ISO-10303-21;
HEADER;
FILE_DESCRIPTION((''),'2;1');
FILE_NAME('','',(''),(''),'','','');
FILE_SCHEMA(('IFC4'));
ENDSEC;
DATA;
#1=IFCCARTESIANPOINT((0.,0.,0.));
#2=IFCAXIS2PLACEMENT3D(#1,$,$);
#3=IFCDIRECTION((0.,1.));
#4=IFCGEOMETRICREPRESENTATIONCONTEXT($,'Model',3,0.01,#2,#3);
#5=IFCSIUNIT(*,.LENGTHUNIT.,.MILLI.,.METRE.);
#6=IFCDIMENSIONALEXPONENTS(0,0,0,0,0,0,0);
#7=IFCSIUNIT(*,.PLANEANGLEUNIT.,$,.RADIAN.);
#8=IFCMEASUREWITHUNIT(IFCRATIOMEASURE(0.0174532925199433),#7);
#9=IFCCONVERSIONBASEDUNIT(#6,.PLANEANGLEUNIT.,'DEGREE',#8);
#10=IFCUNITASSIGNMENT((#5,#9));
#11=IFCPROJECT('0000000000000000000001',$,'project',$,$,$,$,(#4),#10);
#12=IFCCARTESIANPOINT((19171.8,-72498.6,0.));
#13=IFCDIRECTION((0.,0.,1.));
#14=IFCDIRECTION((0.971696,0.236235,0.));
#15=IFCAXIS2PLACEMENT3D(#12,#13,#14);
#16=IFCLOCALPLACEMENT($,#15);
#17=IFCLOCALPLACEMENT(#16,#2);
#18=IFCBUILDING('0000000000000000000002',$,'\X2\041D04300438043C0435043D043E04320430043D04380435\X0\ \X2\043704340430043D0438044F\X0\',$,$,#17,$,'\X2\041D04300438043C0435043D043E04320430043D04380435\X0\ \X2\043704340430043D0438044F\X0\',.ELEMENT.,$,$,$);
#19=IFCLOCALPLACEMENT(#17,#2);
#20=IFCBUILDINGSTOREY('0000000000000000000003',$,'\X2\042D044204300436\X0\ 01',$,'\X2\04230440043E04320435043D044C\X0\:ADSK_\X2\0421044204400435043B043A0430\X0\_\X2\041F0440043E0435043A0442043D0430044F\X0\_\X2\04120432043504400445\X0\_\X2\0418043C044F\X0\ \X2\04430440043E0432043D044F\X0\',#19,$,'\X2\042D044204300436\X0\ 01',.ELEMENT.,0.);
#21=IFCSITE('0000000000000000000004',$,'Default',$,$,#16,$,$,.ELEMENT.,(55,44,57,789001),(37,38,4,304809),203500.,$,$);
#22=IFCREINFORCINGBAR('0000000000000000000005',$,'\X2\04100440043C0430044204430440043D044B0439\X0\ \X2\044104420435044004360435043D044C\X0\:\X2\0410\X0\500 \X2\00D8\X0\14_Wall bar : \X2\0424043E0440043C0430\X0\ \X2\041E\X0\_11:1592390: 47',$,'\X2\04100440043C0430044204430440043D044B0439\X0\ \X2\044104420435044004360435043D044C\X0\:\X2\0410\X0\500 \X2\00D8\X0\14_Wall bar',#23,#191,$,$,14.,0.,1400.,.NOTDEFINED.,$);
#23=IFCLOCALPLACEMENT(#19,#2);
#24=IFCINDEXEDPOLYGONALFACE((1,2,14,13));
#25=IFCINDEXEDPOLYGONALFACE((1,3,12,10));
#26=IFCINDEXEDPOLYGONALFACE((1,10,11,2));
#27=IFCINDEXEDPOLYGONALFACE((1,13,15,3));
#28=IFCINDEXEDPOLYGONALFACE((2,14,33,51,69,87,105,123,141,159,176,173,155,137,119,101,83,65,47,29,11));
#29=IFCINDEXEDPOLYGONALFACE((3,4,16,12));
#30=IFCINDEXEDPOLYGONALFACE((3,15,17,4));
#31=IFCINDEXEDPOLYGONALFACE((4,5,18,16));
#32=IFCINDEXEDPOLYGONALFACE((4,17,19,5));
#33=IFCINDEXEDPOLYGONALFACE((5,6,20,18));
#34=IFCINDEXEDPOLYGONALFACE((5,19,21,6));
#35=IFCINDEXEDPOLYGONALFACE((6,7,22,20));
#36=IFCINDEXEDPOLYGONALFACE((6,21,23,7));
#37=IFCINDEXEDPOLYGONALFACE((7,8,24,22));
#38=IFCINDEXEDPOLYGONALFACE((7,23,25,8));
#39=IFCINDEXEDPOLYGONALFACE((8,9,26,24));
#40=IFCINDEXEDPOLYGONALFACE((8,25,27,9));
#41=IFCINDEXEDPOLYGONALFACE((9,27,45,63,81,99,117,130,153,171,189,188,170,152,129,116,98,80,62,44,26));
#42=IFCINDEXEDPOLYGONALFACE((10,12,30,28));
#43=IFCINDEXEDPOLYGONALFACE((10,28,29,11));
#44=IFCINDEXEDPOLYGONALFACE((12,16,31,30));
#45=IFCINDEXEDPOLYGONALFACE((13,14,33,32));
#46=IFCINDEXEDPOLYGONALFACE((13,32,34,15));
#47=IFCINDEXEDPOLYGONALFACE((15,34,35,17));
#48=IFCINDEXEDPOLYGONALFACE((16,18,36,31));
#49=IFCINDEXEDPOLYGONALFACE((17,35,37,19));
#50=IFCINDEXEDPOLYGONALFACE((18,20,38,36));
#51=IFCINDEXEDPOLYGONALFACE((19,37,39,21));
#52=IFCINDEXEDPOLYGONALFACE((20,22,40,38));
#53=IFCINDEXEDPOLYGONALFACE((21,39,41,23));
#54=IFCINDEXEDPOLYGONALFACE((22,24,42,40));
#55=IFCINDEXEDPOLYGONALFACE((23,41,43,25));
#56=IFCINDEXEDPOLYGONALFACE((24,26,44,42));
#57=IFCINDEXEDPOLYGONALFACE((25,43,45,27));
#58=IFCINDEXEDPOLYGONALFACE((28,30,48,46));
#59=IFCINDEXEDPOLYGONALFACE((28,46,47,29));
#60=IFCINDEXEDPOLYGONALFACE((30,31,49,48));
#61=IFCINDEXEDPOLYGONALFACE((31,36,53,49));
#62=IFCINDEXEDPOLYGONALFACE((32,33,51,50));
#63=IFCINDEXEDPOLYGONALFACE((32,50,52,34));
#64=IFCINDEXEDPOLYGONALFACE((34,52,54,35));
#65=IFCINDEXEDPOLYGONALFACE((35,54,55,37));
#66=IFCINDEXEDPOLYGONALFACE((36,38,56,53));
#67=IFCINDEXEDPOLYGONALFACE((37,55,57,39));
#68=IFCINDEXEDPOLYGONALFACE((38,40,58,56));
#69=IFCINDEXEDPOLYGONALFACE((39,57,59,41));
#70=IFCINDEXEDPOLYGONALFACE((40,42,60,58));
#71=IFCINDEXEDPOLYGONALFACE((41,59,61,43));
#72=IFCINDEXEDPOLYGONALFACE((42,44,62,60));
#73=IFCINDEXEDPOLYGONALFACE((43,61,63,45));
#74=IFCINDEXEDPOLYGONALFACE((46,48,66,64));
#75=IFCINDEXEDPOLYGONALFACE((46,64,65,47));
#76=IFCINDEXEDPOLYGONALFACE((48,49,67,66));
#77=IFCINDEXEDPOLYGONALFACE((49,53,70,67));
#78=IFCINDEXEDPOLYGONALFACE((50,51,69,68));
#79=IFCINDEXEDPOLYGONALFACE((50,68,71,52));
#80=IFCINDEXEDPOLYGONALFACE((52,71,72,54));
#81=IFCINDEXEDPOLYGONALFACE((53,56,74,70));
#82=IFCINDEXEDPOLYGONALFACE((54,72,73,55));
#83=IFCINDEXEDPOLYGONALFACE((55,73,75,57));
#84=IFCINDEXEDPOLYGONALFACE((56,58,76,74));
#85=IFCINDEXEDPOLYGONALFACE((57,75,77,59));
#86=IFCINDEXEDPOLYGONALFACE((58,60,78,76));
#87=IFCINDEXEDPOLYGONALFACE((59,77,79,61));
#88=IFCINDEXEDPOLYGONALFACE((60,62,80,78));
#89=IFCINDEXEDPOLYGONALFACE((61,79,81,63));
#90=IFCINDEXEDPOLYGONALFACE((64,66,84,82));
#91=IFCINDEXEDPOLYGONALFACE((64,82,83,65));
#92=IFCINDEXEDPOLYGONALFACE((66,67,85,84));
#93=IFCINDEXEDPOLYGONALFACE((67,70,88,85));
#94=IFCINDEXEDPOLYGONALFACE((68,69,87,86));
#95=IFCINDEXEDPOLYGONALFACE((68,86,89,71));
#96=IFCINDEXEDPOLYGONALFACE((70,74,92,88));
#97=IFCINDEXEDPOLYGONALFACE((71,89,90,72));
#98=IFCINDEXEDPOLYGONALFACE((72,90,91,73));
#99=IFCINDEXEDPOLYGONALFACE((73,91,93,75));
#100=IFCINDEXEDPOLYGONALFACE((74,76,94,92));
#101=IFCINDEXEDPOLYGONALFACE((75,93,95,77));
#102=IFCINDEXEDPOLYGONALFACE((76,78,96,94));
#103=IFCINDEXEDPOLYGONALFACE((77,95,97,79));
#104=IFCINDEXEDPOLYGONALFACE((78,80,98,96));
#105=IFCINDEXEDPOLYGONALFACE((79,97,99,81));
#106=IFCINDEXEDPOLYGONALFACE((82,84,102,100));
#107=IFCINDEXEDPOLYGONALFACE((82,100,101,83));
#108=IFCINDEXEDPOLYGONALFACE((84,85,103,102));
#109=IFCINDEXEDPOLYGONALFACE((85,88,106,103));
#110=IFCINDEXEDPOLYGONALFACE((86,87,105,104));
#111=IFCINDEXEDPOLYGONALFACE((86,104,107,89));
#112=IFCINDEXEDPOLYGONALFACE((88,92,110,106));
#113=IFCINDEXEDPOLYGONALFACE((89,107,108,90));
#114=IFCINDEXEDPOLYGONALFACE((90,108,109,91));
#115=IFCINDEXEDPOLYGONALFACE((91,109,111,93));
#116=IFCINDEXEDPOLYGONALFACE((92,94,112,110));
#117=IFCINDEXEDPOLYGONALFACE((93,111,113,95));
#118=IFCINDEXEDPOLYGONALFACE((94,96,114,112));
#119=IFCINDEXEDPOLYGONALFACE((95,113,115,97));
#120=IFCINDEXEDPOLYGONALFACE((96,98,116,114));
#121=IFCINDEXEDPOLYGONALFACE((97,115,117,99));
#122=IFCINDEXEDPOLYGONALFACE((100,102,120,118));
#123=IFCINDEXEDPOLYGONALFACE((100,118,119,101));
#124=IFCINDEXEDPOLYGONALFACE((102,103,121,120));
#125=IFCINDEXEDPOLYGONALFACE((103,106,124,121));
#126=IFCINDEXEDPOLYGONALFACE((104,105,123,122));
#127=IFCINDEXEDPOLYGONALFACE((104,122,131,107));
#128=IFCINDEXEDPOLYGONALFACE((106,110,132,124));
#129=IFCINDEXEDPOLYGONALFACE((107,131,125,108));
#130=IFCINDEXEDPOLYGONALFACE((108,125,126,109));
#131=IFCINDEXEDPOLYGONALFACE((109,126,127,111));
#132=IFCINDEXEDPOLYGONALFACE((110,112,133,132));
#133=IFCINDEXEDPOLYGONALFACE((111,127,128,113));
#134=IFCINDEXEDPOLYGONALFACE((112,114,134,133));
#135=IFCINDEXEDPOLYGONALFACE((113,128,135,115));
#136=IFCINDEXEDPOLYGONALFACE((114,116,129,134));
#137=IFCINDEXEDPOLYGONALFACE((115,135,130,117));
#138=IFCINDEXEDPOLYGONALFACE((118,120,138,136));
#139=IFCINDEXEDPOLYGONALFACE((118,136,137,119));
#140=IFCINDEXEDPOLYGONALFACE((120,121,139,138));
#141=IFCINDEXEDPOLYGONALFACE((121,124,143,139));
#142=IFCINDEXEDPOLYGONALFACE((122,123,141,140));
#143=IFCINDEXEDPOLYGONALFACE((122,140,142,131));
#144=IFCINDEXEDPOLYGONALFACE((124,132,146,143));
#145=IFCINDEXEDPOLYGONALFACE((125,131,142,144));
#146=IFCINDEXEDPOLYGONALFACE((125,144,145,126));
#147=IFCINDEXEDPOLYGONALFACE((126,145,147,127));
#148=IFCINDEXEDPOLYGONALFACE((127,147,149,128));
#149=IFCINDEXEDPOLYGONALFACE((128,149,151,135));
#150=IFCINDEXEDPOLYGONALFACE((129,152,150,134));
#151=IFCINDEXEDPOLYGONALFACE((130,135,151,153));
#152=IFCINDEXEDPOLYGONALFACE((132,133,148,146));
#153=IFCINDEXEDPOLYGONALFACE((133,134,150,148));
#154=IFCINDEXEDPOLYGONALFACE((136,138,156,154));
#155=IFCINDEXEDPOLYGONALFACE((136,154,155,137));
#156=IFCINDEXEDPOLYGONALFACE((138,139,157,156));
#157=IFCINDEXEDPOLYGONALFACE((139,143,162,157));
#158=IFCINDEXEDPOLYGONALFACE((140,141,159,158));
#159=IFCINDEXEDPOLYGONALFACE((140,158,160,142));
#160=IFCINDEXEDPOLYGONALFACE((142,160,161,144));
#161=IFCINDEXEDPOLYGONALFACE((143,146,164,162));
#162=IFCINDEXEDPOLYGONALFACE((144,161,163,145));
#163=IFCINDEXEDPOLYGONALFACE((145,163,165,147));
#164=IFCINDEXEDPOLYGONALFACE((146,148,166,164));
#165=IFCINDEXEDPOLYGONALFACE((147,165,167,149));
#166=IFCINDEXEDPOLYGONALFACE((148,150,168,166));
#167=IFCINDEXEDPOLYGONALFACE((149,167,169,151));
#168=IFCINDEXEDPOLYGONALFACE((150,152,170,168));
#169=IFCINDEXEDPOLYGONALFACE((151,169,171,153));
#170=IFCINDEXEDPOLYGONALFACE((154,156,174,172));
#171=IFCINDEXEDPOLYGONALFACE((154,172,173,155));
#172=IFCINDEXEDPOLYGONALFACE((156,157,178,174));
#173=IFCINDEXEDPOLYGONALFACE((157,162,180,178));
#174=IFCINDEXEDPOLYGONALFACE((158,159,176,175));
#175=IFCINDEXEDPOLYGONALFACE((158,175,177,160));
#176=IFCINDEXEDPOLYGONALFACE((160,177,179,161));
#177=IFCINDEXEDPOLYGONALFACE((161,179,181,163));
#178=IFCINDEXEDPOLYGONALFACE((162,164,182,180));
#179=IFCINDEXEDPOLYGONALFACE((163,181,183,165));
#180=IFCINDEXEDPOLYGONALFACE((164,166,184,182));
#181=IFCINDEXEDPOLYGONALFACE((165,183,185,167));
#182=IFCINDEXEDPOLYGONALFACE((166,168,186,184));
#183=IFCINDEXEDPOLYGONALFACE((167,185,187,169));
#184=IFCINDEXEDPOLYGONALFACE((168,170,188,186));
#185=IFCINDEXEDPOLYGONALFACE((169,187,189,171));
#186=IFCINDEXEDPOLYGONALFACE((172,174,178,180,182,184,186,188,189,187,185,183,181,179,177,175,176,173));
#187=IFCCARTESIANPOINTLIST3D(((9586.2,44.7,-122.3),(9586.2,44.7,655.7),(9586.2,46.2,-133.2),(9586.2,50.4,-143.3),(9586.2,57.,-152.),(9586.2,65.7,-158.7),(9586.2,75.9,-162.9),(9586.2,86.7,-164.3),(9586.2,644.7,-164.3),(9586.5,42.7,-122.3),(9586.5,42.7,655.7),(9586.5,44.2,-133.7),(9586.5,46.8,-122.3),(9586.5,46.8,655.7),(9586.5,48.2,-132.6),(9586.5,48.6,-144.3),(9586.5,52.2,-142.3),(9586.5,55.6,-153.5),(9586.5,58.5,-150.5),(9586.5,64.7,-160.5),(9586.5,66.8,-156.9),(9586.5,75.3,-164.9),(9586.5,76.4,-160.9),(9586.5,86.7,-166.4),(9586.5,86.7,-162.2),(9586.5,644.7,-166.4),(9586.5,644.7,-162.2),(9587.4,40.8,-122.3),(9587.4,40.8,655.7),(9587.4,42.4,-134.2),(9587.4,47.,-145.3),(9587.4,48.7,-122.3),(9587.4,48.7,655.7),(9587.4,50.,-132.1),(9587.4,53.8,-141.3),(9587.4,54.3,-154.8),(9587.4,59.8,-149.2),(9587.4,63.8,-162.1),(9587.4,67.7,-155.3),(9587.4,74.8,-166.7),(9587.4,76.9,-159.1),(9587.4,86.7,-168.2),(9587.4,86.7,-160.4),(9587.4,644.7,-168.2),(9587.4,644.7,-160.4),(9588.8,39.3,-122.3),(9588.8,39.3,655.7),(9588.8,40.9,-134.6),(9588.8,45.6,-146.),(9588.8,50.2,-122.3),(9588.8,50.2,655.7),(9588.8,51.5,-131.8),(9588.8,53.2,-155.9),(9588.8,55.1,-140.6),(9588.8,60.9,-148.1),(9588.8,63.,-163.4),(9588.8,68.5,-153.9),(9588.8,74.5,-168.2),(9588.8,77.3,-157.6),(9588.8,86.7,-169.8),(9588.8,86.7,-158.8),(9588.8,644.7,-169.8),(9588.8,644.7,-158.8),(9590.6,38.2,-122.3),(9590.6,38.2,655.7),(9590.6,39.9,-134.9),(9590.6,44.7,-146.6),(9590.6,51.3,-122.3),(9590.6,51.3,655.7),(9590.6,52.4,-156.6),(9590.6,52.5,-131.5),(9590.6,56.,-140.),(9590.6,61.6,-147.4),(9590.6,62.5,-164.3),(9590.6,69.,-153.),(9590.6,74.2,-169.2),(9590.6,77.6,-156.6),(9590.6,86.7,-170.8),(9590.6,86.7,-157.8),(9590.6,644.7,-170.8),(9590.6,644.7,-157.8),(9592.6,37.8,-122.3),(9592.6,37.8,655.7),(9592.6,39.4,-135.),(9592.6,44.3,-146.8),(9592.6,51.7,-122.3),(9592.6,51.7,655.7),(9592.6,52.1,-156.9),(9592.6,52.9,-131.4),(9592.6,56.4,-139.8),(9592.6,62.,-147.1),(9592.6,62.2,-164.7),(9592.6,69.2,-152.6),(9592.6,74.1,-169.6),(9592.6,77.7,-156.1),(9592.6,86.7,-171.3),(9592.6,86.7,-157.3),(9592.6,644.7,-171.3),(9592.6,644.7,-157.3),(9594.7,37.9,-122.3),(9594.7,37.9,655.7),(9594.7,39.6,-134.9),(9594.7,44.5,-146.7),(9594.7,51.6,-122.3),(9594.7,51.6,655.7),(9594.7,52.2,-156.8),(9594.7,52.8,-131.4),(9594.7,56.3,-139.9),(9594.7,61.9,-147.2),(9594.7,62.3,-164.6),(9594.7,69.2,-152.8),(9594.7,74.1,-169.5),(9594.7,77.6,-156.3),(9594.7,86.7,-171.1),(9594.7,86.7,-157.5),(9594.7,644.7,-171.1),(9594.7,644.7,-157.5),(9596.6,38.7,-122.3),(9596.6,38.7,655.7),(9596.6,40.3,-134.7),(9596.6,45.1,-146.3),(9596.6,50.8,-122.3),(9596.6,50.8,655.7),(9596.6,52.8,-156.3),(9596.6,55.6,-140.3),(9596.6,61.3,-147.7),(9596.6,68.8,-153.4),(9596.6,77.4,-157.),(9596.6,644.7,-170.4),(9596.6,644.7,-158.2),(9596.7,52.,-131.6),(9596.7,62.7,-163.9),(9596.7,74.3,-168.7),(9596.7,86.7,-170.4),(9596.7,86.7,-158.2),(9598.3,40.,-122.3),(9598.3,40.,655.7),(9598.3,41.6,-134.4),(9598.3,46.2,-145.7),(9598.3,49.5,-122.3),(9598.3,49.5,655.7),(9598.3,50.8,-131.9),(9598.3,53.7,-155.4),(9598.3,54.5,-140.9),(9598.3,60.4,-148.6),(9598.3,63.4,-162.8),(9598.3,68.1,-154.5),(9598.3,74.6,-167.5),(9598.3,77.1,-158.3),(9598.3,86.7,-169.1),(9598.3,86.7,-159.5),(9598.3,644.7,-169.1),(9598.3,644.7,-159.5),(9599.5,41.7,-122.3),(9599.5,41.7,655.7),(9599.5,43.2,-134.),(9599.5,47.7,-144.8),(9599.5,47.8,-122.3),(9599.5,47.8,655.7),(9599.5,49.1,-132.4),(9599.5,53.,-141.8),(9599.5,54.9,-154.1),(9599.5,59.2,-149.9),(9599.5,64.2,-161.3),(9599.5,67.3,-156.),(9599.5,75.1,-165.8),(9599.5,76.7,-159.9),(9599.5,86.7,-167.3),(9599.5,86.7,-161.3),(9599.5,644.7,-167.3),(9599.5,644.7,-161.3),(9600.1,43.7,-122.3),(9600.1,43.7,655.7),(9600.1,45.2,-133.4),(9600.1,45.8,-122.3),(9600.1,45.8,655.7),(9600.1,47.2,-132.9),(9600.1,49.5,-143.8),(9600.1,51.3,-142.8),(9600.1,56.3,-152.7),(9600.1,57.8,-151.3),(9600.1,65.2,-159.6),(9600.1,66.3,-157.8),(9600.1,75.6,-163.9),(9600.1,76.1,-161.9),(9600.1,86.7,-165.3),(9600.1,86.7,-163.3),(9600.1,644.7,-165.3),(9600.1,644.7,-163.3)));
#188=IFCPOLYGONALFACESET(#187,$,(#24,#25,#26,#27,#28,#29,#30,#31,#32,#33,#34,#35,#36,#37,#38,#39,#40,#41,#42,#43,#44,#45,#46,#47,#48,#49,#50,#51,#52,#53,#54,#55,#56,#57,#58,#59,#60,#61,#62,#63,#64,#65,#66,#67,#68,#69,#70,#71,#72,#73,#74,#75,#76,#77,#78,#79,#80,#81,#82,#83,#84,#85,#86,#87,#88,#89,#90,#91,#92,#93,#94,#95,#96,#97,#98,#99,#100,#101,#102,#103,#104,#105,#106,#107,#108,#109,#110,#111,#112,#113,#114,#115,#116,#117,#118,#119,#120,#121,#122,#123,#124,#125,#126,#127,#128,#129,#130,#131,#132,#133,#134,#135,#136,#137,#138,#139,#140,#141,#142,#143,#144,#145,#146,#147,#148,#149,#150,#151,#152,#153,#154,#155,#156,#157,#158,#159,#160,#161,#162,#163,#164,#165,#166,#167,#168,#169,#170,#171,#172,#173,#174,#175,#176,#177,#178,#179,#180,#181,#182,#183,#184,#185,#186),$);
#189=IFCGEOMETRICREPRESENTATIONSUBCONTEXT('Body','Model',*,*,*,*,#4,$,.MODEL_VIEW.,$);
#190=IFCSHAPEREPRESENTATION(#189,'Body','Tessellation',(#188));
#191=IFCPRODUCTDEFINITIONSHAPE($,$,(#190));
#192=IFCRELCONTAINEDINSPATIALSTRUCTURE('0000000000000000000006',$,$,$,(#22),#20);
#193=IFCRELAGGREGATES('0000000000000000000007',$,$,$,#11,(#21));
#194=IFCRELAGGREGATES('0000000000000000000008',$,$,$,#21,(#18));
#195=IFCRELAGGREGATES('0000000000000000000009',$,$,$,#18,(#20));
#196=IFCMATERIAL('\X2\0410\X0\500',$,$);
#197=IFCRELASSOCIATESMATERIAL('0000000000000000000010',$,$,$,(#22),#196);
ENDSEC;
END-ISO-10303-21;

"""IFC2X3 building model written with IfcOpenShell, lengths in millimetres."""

from ifc_helpers import new_model, entity, si_unit, converted_unit, direction, frame, origin, place, context, subcontext, project, spatial, material, element, save


model = new_model("IFC2X3")

# Units and contexts
model_context = context("Model", 3, precision=0.01, world=origin(), true_north=direction((0.0, 1.0)))
body_context = subcontext(model_context, "Body", "Model", "MODEL_VIEW")
ifc_project = project(units=[si_unit("LENGTHUNIT", "METRE", prefix="MILLI"), converted_unit("PLANEANGLEUNIT", "DEGREE", entity("IfcRatioMeasure", 0.0174532925199433), si_unit("PLANEANGLEUNIT", "RADIAN"), dimensions=[0, 0, 0, 0, 0, 0, 0])], contexts=[model_context])

# Site, building, storey
site_placement = place(None, frame((19171.8, -72498.6, 0.0), z_axis=(0.0, 0.0, 1.0), x_axis=(0.971696, 0.236235, 0.0)))
site = spatial("IfcSite", under=ifc_project, at=site_placement, Name="Default", CompositionType="ELEMENT", RefLatitude=(55, 44, 57, 789001), RefLongitude=(37, 38, 4, 304809), RefElevation=203500.0)
building_placement = place(site_placement, origin())
building = spatial("IfcBuilding", under=site, at=building_placement, Name="Наименование здания", LongName="Наименование здания", CompositionType="ELEMENT")
storey_placement = place(building_placement, origin())
storey = spatial("IfcBuildingStorey", under=building, at=storey_placement, Name="Этаж 01", ObjectType="Уровень:ADSK_Стрелка_Проектная_Вверх_Имя уровня", LongName="Этаж 01", CompositionType="ELEMENT", Elevation=0.0)

# Reinforcing bar
ifc_material = material(Name="А500")
placement = place(storey_placement, origin())
element("IfcReinforcingBar", 1, at=placement, inside=storey, material=ifc_material, Name="Арматурный стержень:А500 Ø14_Wall bar : Форма О_11:1592390: 47", ObjectType="Арматурный стержень:А500 Ø14_Wall bar", BarLength=1400.0, BarRole="NOTDEFINED", CrossSectionArea=0.0, NominalDiameter=14.0, context=body_context, shape_type="AdvancedSweptSolid", body=[
    entity("IfcSweptDiskSolid", entity("IfcCompositeCurve", [entity("IfcCompositeCurveSegment", "CONTINUOUS", True, entity("IfcPolyline", [entity("IfcCartesianPoint", [9593.1, 44.7, 655.7]), entity("IfcCartesianPoint", [9593.1, 44.7, -122.3])])), entity("IfcCompositeCurveSegment", "CONTINUOUS", True, entity("IfcTrimmedCurve", entity("IfcCircle", entity("IfcAxis2Placement3D", entity("IfcCartesianPoint", [9593.1, 86.7, -122.3]), entity("IfcDirection", [1.0, 0.0, 0.0]), entity("IfcDirection", [0.0, 0.0, -1.0])), 42.0), [entity("IfcParameterValue", 270.0)], [entity("IfcParameterValue", 360.0)], True, "PARAMETER")), entity("IfcCompositeCurveSegment", "CONTINUOUS", True, entity("IfcPolyline", [entity("IfcCartesianPoint", [9593.1, 86.7, -164.3]), entity("IfcCartesianPoint", [9593.1, 644.7, -164.3])]))], False), 7.0, None, 0.0, 92.0),
])

save(model, "model.ifc")
